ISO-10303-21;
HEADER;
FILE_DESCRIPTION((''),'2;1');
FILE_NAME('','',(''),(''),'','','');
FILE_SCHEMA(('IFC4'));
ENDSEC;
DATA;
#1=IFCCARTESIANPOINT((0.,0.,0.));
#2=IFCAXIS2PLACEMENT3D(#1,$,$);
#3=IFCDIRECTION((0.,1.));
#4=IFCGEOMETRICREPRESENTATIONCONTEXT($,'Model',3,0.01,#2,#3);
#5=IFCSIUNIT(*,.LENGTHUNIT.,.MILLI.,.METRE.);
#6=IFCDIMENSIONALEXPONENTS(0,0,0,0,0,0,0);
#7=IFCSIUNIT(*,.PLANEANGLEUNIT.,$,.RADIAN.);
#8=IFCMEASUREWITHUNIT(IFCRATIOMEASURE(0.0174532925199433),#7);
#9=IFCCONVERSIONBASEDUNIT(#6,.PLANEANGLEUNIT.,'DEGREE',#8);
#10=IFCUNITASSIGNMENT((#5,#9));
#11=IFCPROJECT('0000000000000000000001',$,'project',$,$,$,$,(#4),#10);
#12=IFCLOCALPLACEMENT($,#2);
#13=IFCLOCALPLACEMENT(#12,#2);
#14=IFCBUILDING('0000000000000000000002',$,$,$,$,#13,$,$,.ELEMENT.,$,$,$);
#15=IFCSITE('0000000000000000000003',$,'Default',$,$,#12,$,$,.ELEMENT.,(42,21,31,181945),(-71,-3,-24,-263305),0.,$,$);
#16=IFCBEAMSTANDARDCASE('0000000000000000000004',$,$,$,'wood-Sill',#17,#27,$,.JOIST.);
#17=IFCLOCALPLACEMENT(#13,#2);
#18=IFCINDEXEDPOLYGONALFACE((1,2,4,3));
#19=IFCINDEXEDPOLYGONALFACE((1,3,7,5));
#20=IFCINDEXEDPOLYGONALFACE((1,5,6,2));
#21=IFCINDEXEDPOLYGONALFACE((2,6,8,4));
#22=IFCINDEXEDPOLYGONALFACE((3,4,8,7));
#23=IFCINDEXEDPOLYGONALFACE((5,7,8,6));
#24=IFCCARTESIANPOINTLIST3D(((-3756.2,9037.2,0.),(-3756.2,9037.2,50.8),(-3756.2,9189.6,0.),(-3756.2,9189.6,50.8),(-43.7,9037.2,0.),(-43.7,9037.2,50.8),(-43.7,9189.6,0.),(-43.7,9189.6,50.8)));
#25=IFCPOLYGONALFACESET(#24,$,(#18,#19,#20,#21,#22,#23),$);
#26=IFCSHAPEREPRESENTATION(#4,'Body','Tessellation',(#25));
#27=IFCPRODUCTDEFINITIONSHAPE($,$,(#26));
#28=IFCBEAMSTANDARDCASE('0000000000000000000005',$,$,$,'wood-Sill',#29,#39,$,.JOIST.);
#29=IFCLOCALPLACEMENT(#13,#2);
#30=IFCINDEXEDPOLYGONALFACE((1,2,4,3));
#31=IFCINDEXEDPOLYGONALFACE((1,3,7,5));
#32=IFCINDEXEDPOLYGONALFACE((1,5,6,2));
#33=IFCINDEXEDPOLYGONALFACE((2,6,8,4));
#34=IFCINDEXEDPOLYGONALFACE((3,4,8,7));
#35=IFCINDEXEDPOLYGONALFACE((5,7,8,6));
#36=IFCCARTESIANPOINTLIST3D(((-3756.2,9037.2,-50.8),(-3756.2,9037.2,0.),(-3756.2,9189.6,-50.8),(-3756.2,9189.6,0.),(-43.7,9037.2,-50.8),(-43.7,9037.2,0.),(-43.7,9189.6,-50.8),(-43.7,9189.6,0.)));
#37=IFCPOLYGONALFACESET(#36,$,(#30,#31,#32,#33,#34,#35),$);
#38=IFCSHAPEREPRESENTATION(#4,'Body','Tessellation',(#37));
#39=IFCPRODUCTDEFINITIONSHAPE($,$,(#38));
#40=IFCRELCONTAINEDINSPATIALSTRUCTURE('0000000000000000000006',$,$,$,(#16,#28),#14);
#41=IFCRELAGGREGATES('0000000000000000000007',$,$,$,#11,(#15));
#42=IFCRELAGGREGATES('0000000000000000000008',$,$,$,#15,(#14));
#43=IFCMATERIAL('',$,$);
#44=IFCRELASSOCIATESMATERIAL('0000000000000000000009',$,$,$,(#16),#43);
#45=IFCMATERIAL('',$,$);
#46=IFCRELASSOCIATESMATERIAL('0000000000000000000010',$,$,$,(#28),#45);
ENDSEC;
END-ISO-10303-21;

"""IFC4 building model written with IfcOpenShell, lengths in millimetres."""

from ifc_helpers import new_model, entity, si_unit, converted_unit, direction, frame, origin, place, context, project, spatial, rectangle, extrude, material, element, save


model = new_model("IFC4")

# Units and contexts
model_context = context("Model", 3, precision=0.01, world=origin(), true_north=direction((0.0, 1.0)))
ifc_project = project(units=[si_unit("LENGTHUNIT", "METRE", prefix="MILLI"), converted_unit("PLANEANGLEUNIT", "DEGREE", entity("IfcRatioMeasure", 0.0174532925199433), si_unit("PLANEANGLEUNIT", "RADIAN"), dimensions=[0, 0, 0, 0, 0, 0, 0])], contexts=[model_context])

# Site, building
site_placement = place(None, origin())
site = spatial("IfcSite", under=ifc_project, at=site_placement, Name="Default", CompositionType="ELEMENT", RefLatitude=(42, 21, 31, 181945), RefLongitude=(-71, -3, -24, -263305), RefElevation=0.0)
building_placement = place(site_placement, origin())
building = spatial("IfcBuilding", under=site, at=building_placement, CompositionType="ELEMENT")

# Shared definitions
placement_1 = place(building_placement, origin())
placement_2 = place(placement_1, frame((-1899.9, 10969.7, 0.0), z_axis=(0.0, 0.0, 1.0), x_axis=(0.0, -1.0, 0.0)))

# Beams
ifc_material_1 = material(Name="")
beam_1_placement = place(placement_2, frame((1856.2, 0.0, 0.0), z_axis=(0.0, 0.0, 1.0), x_axis=(0.0, -1.0, 0.0)))
element("IfcBeamStandardCase", 1, at=beam_1_placement, inside=building, material=ifc_material_1, ObjectType="wood-Sill", PredefinedType="JOIST", context=model_context, shape_type="SweptSolid", body=[
    extrude(rectangle(XDim=3712.5, YDim=152.4), origin(), (0.0, 0.0, 1.0), 50.8),
])
ifc_material_2 = material(Name="")
beam_2_placement = place(placement_2, frame((1856.2, 0.0, -50.8), z_axis=(0.0, 0.0, 1.0), x_axis=(0.0, -1.0, 0.0)))
element("IfcBeamStandardCase", 2, at=beam_2_placement, inside=building, material=ifc_material_2, ObjectType="wood-Sill", PredefinedType="JOIST", context=model_context, shape_type="SweptSolid", body=[
    extrude(rectangle(XDim=3712.5, YDim=152.4), origin(), (0.0, 0.0, 1.0), 50.8),
])

save(model, "model.ifc")
